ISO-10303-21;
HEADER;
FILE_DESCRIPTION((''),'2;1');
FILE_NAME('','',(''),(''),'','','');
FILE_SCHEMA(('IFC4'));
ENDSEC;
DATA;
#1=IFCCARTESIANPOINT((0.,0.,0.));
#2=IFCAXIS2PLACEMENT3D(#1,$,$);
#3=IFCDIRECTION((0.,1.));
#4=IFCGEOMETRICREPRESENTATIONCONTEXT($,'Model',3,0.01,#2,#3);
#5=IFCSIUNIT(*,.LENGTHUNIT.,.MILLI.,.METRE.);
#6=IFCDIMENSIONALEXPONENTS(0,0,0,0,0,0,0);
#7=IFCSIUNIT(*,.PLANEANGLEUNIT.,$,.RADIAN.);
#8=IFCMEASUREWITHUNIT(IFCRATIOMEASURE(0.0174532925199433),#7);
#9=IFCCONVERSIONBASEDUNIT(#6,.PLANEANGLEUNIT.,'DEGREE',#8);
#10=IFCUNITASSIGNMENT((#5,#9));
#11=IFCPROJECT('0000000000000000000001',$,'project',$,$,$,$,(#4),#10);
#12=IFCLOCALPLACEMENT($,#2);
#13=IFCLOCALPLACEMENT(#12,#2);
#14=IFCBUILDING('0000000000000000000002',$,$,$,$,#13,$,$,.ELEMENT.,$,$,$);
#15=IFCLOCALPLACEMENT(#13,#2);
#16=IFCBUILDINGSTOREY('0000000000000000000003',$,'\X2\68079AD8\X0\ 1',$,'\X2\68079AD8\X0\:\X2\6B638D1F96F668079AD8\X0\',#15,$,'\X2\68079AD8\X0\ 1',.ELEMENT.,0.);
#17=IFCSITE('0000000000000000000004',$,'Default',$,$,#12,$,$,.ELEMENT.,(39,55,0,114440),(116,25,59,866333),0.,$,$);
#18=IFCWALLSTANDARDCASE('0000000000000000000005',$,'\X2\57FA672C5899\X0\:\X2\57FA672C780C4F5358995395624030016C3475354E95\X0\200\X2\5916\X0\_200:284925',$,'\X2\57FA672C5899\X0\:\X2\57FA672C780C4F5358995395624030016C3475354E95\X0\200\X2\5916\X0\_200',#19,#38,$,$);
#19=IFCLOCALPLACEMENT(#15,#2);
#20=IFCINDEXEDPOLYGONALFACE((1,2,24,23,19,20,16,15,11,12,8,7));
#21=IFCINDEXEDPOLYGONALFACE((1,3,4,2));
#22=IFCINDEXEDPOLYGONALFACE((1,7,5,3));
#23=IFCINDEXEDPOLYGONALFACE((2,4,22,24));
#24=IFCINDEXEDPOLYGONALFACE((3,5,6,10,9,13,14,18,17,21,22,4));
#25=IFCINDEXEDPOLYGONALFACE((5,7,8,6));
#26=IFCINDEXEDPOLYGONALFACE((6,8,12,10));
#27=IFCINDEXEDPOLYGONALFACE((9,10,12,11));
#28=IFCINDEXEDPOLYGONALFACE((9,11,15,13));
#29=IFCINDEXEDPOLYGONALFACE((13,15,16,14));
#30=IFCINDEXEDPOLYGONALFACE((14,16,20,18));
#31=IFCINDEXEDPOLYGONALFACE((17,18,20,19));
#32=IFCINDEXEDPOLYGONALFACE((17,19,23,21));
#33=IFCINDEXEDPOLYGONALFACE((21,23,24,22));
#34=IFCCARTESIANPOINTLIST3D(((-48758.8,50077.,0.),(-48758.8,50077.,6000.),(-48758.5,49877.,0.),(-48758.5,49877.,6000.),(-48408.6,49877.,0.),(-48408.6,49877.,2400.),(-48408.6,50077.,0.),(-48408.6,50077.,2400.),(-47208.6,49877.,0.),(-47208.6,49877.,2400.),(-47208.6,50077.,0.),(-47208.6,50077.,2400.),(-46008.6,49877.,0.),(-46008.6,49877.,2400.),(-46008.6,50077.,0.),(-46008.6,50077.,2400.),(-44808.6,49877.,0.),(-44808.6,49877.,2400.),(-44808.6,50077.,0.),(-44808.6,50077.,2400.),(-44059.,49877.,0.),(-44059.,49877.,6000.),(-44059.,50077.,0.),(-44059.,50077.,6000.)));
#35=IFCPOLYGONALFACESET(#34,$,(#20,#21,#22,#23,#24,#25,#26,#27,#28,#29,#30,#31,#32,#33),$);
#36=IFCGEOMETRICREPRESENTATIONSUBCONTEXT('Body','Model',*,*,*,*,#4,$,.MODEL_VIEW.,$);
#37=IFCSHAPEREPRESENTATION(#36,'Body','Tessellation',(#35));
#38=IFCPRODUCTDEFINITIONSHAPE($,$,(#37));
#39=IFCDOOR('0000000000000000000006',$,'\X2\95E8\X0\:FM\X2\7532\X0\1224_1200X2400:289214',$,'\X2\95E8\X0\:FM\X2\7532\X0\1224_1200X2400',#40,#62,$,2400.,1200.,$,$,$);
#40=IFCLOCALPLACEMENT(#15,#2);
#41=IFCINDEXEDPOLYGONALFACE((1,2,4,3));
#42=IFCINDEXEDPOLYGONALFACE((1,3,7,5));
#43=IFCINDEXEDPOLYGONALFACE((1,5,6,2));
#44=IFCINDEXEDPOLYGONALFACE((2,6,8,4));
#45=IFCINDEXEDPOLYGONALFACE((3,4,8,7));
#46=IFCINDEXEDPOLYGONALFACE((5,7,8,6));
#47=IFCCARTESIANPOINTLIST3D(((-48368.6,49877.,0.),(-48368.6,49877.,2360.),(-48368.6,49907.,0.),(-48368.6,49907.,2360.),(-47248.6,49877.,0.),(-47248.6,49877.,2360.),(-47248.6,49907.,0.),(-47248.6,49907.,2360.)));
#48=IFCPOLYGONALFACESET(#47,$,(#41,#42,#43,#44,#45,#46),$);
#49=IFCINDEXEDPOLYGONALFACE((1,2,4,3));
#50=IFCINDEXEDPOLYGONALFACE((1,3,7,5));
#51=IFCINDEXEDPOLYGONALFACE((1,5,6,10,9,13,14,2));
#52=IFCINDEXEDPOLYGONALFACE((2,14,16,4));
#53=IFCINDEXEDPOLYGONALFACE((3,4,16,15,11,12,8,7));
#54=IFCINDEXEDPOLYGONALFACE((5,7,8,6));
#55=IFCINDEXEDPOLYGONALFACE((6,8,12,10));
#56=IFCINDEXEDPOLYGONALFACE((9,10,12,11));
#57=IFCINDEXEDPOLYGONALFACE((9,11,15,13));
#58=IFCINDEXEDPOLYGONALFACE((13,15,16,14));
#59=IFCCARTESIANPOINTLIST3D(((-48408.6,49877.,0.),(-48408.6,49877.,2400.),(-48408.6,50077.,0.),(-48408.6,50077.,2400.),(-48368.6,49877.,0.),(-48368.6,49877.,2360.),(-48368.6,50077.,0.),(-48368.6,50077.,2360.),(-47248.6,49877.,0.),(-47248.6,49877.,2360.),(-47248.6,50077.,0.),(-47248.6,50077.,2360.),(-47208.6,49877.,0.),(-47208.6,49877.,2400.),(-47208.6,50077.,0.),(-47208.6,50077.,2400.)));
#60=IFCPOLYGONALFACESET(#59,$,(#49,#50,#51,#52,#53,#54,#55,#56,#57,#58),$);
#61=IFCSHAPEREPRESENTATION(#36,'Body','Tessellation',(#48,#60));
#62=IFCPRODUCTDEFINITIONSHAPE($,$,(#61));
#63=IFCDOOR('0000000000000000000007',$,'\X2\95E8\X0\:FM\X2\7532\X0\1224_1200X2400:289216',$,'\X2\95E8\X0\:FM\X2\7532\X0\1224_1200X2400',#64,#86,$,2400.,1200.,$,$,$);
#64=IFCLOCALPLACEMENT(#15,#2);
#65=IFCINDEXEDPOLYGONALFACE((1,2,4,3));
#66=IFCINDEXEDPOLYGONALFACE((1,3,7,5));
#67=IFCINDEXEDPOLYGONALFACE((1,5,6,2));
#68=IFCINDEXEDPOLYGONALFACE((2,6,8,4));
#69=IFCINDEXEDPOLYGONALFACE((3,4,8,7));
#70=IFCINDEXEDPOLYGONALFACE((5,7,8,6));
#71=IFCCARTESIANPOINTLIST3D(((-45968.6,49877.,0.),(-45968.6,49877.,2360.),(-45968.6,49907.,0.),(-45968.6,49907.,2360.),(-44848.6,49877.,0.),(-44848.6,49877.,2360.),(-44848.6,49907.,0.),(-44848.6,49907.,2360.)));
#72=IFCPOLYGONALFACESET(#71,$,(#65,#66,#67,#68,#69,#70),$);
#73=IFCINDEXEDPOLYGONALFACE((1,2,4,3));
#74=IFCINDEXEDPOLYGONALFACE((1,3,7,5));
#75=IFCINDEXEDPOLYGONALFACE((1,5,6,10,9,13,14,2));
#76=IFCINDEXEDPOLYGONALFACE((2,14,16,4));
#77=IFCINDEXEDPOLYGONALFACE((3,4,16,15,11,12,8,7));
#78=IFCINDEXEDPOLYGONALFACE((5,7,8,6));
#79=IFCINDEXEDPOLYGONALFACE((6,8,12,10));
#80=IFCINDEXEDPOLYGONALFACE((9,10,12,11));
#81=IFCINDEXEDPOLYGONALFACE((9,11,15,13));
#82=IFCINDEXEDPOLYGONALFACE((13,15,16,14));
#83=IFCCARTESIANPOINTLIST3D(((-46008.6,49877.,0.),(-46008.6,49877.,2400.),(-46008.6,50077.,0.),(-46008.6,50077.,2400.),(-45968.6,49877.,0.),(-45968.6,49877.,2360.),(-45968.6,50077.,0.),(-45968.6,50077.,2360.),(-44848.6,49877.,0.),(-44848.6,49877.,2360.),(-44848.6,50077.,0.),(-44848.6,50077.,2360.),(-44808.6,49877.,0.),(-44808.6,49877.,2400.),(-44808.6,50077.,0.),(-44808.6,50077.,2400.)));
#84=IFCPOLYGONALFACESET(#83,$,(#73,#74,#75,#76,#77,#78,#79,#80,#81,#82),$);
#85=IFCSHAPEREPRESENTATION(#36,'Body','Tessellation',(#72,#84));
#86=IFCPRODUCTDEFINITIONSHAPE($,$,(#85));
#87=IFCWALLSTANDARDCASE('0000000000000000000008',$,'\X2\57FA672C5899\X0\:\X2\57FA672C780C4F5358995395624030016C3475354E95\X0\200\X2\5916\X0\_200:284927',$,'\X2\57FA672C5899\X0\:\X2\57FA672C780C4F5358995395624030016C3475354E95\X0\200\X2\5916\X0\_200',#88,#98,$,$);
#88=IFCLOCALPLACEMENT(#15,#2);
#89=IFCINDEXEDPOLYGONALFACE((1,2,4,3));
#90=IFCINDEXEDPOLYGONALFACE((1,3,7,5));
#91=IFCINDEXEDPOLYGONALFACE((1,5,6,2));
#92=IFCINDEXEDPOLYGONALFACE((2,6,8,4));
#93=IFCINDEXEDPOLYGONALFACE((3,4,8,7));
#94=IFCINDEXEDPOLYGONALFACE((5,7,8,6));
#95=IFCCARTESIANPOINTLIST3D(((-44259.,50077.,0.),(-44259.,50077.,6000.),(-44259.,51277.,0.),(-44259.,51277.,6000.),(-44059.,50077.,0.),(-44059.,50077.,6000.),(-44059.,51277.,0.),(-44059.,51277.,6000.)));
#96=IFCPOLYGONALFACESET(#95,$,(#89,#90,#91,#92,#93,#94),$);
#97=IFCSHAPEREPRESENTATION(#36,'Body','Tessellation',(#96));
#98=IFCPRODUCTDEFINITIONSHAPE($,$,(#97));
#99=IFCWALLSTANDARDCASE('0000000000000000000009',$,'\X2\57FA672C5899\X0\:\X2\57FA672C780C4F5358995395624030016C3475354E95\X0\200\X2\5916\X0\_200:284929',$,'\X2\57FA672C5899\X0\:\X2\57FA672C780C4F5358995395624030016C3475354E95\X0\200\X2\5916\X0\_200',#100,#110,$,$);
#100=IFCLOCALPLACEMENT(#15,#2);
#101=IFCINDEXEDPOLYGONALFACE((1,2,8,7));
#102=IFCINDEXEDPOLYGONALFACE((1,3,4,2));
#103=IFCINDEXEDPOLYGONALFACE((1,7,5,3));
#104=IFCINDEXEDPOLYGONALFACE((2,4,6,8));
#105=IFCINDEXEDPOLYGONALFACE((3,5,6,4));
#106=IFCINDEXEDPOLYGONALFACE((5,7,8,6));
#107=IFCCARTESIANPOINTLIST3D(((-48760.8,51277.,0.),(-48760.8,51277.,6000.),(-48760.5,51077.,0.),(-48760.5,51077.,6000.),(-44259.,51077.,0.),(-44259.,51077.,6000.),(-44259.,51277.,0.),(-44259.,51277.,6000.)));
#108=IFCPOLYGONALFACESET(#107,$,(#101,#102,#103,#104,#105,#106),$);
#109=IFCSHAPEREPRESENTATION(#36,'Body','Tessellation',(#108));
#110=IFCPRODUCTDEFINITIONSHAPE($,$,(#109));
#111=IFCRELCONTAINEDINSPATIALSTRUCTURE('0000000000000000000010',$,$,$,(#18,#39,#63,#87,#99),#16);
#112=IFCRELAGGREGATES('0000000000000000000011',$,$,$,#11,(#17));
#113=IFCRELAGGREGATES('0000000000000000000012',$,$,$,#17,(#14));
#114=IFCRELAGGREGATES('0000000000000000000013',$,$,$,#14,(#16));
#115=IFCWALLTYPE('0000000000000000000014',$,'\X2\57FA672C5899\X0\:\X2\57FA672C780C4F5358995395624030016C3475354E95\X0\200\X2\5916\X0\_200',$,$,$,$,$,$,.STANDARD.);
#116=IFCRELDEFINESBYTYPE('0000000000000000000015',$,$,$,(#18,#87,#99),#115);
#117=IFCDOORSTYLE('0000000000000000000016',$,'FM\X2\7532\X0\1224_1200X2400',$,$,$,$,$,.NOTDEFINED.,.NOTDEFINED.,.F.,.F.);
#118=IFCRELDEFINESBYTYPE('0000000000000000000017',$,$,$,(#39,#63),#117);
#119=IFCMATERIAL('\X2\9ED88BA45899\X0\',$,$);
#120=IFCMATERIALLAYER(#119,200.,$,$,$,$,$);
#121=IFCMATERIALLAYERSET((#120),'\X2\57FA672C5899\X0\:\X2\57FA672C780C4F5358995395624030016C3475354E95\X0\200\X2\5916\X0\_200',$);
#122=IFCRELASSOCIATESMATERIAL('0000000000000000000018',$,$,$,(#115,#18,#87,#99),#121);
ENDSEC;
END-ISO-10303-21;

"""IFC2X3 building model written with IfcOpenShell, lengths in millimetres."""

from ifc_helpers import new_model, entity, si_unit, converted_unit, direction, frame, frame_2d, origin, place, context, subcontext, project, spatial, polyline, rectangle, outline, extrude, source, transform, mapped, material, layer, layer_set, layer_usage, type_object, type_shapes, element, fill, save


model = new_model("IFC2X3")

# Units and contexts
model_context = context("Model", 3, precision=0.01, world=origin(), true_north=direction((0.0, 1.0)))
body_context = subcontext(model_context, "Body", "Model", "MODEL_VIEW")
ifc_project = project(units=[si_unit("LENGTHUNIT", "METRE", prefix="MILLI"), converted_unit("PLANEANGLEUNIT", "DEGREE", entity("IfcRatioMeasure", 0.0174532925199433), si_unit("PLANEANGLEUNIT", "RADIAN"), dimensions=[0, 0, 0, 0, 0, 0, 0])], contexts=[model_context])

# Site, building, storey
site_placement = place(None, origin())
site = spatial("IfcSite", under=ifc_project, at=site_placement, Name="Default", CompositionType="ELEMENT", RefLatitude=(39, 55, 0, 114440), RefLongitude=(116, 25, 59, 866333), RefElevation=0.0)
building_placement = place(site_placement, origin())
building = spatial("IfcBuilding", under=site, at=building_placement, CompositionType="ELEMENT")
storey_placement = place(building_placement, origin())
storey = spatial("IfcBuildingStorey", under=building, at=storey_placement, Name="标高 1", ObjectType="标高:正负零标高", LongName="标高 1", CompositionType="ELEMENT", Elevation=0.0)

# Shared definitions
ifc_material = material(Name="默认墙")
ifc_layer_1 = layer(ifc_material, 200.0)
ifc_layer_set_1 = layer_set([ifc_layer_1], Name="基本墙:基本砌体墙厕所、水电井200外_200")
wall_type_1 = type_object("IfcWallType", Name="基本墙:基本砌体墙厕所、水电井200外_200", PredefinedType="STANDARD", material=ifc_layer_set_1)

# Wall, openings, doors
ifc_layer_usage_1 = layer_usage(ifc_layer_set_1, "AXIS2", "NEGATIVE", 100.0)
wall_1_placement = place(building_placement, frame((-44059.0, 49977.0, 0.0), z_axis=(0.0, 0.0, 1.0), x_axis=(-1.0, 0.0, 0.0)))
wall_1 = element("IfcWallStandardCase", 1, at=wall_1_placement, inside=storey, type_object=wall_type_1, material=ifc_layer_usage_1, Name="基本墙:基本砌体墙厕所、水电井200外_200:284925", ObjectType="基本墙:基本砌体墙厕所、水电井200外_200", context=body_context, shape_type="SweptSolid", body=[
    extrude(outline(polyline([(0.0, -100.0), (200.0, -100.0), (4699.8, -100.0), (4699.5, 100.0), (0.0, 100.0), (0.0, -100.0)])), origin(), (0.0, 0.0, 1.0), 6000.0),
])
opening_1_placement = place(wall_1_placement, frame((3149.6, -100.0, 0.0)))
opening_1 = element("IfcOpeningElement", 2, at=opening_1_placement, cuts=wall_1, ObjectType="Opening", context=body_context, shape_type="SweptSolid", body=[
    extrude(rectangle(XDim=2400.0, YDim=1200.0, at=frame_2d((1200.0, 600.0), x_axis=(1.0, 0.0))), frame((0.0, 0.0, 0.0), z_axis=(0.0, 1.0, 0.0), x_axis=(0.0, 0.0, 1.0)), (0.0, 0.0, 1.0), 200.0),
])
opening_2_placement = place(wall_1_placement, frame((749.6, -100.0, 0.0)))
opening_2 = element("IfcOpeningElement", 3, at=opening_2_placement, cuts=wall_1, ObjectType="Opening", context=body_context, shape_type="SweptSolid", body=[
    extrude(rectangle(XDim=2400.0, YDim=1200.0, at=frame_2d((1200.0, 600.0), x_axis=(1.0, 0.0))), frame((0.0, 0.0, 0.0), z_axis=(0.0, 1.0, 0.0), x_axis=(0.0, 0.0, 1.0)), (0.0, 0.0, 1.0), 200.0),
])
door_style = type_object("IfcDoorStyle", Name="FM甲1224_1200X2400", ConstructionType="NOTDEFINED", OperationType="NOTDEFINED", ParameterTakesPrecedence=False, Sizeable=False)
shared_shape_1 = source(origin(), body_context, "Body", "SweptSolid", [
    extrude(rectangle(XDim=30.0, YDim=1120.0, at=frame_2d((0.0, 0.0), x_axis=(1.0, 0.0))), frame((600.0, -715.0, 0.0), z_axis=(0.0, 0.0, 1.0), x_axis=(0.0, 1.0, 0.0)), (0.0, 0.0, 1.0), 2360.0),
    extrude(outline(polyline([(-1170.0, 560.0), (1190.0, 560.0), (1190.0, 600.0), (-1210.0, 600.0), (-1210.0, -600.0), (1190.0, -600.0), (1190.0, -560.0), (-1170.0, -560.0), (-1170.0, 560.0)])), frame((600.0, -900.0, 1190.0), z_axis=(0.0, 1.0, 0.0), x_axis=(0.0, 0.0, -1.0)), (0.0, 0.0, 1.0), 200.0),
])
type_shapes(door_style, [shared_shape_1])
door_1_placement = place(opening_1_placement, frame((0.0, 900.0, 0.0)))
door_1 = element("IfcDoor", 4, at=door_1_placement, inside=storey, type_object=door_style, Name="门:FM甲1224_1200X2400:289214", ObjectType="门:FM甲1224_1200X2400", OverallHeight=2400.0, OverallWidth=1200.0, context=body_context, shape_type="MappedRepresentation", body=[
    mapped(shared_shape_1, transform((0.0, 0.0, 0.0), scale=1.0)),
])
fill(opening_1, door_1)
door_2_placement = place(opening_2_placement, frame((0.0, 900.0, 0.0)))
door_2 = element("IfcDoor", 5, at=door_2_placement, inside=storey, type_object=door_style, Name="门:FM甲1224_1200X2400:289216", ObjectType="门:FM甲1224_1200X2400", OverallHeight=2400.0, OverallWidth=1200.0, context=body_context, shape_type="MappedRepresentation", body=[
    mapped(shared_shape_1, transform((0.0, 0.0, 0.0), scale=1.0)),
])
fill(opening_2, door_2)

# Walls
ifc_layer_usage_2 = layer_usage(ifc_layer_set_1, "AXIS2", "NEGATIVE", 100.0)
wall_2_placement = place(building_placement, frame((-44159.0, 51277.0, 0.0), z_axis=(0.0, 0.0, 1.0), x_axis=(0.0, -1.0, 0.0)))
element("IfcWallStandardCase", 6, at=wall_2_placement, inside=storey, type_object=wall_type_1, material=ifc_layer_usage_2, Name="基本墙:基本砌体墙厕所、水电井200外_200:284927", ObjectType="基本墙:基本砌体墙厕所、水电井200外_200", context=body_context, shape_type="SweptSolid", body=[
    extrude(rectangle(XDim=1200.0, YDim=200.0, at=frame_2d((600.0, 0.0), x_axis=(-1.0, 0.0))), origin(), (0.0, 0.0, 1.0), 6000.0),
])
ifc_layer_usage_3 = layer_usage(ifc_layer_set_1, "AXIS2", "NEGATIVE", 100.0)
wall_3_placement = place(building_placement, frame((-48760.8, 51177.0, 0.0)))
element("IfcWallStandardCase", 7, at=wall_3_placement, inside=storey, type_object=wall_type_1, material=ifc_layer_usage_3, Name="基本墙:基本砌体墙厕所、水电井200外_200:284929", ObjectType="基本墙:基本砌体墙厕所、水电井200外_200", context=body_context, shape_type="SweptSolid", body=[
    extrude(outline(polyline([(4501.8, -100.0), (4501.8, 100.0), (0.0, 100.0), (0.3, -100.0), (4501.8, -100.0)])), origin(), (0.0, 0.0, 1.0), 6000.0),
])

save(model, "model.ifc")
